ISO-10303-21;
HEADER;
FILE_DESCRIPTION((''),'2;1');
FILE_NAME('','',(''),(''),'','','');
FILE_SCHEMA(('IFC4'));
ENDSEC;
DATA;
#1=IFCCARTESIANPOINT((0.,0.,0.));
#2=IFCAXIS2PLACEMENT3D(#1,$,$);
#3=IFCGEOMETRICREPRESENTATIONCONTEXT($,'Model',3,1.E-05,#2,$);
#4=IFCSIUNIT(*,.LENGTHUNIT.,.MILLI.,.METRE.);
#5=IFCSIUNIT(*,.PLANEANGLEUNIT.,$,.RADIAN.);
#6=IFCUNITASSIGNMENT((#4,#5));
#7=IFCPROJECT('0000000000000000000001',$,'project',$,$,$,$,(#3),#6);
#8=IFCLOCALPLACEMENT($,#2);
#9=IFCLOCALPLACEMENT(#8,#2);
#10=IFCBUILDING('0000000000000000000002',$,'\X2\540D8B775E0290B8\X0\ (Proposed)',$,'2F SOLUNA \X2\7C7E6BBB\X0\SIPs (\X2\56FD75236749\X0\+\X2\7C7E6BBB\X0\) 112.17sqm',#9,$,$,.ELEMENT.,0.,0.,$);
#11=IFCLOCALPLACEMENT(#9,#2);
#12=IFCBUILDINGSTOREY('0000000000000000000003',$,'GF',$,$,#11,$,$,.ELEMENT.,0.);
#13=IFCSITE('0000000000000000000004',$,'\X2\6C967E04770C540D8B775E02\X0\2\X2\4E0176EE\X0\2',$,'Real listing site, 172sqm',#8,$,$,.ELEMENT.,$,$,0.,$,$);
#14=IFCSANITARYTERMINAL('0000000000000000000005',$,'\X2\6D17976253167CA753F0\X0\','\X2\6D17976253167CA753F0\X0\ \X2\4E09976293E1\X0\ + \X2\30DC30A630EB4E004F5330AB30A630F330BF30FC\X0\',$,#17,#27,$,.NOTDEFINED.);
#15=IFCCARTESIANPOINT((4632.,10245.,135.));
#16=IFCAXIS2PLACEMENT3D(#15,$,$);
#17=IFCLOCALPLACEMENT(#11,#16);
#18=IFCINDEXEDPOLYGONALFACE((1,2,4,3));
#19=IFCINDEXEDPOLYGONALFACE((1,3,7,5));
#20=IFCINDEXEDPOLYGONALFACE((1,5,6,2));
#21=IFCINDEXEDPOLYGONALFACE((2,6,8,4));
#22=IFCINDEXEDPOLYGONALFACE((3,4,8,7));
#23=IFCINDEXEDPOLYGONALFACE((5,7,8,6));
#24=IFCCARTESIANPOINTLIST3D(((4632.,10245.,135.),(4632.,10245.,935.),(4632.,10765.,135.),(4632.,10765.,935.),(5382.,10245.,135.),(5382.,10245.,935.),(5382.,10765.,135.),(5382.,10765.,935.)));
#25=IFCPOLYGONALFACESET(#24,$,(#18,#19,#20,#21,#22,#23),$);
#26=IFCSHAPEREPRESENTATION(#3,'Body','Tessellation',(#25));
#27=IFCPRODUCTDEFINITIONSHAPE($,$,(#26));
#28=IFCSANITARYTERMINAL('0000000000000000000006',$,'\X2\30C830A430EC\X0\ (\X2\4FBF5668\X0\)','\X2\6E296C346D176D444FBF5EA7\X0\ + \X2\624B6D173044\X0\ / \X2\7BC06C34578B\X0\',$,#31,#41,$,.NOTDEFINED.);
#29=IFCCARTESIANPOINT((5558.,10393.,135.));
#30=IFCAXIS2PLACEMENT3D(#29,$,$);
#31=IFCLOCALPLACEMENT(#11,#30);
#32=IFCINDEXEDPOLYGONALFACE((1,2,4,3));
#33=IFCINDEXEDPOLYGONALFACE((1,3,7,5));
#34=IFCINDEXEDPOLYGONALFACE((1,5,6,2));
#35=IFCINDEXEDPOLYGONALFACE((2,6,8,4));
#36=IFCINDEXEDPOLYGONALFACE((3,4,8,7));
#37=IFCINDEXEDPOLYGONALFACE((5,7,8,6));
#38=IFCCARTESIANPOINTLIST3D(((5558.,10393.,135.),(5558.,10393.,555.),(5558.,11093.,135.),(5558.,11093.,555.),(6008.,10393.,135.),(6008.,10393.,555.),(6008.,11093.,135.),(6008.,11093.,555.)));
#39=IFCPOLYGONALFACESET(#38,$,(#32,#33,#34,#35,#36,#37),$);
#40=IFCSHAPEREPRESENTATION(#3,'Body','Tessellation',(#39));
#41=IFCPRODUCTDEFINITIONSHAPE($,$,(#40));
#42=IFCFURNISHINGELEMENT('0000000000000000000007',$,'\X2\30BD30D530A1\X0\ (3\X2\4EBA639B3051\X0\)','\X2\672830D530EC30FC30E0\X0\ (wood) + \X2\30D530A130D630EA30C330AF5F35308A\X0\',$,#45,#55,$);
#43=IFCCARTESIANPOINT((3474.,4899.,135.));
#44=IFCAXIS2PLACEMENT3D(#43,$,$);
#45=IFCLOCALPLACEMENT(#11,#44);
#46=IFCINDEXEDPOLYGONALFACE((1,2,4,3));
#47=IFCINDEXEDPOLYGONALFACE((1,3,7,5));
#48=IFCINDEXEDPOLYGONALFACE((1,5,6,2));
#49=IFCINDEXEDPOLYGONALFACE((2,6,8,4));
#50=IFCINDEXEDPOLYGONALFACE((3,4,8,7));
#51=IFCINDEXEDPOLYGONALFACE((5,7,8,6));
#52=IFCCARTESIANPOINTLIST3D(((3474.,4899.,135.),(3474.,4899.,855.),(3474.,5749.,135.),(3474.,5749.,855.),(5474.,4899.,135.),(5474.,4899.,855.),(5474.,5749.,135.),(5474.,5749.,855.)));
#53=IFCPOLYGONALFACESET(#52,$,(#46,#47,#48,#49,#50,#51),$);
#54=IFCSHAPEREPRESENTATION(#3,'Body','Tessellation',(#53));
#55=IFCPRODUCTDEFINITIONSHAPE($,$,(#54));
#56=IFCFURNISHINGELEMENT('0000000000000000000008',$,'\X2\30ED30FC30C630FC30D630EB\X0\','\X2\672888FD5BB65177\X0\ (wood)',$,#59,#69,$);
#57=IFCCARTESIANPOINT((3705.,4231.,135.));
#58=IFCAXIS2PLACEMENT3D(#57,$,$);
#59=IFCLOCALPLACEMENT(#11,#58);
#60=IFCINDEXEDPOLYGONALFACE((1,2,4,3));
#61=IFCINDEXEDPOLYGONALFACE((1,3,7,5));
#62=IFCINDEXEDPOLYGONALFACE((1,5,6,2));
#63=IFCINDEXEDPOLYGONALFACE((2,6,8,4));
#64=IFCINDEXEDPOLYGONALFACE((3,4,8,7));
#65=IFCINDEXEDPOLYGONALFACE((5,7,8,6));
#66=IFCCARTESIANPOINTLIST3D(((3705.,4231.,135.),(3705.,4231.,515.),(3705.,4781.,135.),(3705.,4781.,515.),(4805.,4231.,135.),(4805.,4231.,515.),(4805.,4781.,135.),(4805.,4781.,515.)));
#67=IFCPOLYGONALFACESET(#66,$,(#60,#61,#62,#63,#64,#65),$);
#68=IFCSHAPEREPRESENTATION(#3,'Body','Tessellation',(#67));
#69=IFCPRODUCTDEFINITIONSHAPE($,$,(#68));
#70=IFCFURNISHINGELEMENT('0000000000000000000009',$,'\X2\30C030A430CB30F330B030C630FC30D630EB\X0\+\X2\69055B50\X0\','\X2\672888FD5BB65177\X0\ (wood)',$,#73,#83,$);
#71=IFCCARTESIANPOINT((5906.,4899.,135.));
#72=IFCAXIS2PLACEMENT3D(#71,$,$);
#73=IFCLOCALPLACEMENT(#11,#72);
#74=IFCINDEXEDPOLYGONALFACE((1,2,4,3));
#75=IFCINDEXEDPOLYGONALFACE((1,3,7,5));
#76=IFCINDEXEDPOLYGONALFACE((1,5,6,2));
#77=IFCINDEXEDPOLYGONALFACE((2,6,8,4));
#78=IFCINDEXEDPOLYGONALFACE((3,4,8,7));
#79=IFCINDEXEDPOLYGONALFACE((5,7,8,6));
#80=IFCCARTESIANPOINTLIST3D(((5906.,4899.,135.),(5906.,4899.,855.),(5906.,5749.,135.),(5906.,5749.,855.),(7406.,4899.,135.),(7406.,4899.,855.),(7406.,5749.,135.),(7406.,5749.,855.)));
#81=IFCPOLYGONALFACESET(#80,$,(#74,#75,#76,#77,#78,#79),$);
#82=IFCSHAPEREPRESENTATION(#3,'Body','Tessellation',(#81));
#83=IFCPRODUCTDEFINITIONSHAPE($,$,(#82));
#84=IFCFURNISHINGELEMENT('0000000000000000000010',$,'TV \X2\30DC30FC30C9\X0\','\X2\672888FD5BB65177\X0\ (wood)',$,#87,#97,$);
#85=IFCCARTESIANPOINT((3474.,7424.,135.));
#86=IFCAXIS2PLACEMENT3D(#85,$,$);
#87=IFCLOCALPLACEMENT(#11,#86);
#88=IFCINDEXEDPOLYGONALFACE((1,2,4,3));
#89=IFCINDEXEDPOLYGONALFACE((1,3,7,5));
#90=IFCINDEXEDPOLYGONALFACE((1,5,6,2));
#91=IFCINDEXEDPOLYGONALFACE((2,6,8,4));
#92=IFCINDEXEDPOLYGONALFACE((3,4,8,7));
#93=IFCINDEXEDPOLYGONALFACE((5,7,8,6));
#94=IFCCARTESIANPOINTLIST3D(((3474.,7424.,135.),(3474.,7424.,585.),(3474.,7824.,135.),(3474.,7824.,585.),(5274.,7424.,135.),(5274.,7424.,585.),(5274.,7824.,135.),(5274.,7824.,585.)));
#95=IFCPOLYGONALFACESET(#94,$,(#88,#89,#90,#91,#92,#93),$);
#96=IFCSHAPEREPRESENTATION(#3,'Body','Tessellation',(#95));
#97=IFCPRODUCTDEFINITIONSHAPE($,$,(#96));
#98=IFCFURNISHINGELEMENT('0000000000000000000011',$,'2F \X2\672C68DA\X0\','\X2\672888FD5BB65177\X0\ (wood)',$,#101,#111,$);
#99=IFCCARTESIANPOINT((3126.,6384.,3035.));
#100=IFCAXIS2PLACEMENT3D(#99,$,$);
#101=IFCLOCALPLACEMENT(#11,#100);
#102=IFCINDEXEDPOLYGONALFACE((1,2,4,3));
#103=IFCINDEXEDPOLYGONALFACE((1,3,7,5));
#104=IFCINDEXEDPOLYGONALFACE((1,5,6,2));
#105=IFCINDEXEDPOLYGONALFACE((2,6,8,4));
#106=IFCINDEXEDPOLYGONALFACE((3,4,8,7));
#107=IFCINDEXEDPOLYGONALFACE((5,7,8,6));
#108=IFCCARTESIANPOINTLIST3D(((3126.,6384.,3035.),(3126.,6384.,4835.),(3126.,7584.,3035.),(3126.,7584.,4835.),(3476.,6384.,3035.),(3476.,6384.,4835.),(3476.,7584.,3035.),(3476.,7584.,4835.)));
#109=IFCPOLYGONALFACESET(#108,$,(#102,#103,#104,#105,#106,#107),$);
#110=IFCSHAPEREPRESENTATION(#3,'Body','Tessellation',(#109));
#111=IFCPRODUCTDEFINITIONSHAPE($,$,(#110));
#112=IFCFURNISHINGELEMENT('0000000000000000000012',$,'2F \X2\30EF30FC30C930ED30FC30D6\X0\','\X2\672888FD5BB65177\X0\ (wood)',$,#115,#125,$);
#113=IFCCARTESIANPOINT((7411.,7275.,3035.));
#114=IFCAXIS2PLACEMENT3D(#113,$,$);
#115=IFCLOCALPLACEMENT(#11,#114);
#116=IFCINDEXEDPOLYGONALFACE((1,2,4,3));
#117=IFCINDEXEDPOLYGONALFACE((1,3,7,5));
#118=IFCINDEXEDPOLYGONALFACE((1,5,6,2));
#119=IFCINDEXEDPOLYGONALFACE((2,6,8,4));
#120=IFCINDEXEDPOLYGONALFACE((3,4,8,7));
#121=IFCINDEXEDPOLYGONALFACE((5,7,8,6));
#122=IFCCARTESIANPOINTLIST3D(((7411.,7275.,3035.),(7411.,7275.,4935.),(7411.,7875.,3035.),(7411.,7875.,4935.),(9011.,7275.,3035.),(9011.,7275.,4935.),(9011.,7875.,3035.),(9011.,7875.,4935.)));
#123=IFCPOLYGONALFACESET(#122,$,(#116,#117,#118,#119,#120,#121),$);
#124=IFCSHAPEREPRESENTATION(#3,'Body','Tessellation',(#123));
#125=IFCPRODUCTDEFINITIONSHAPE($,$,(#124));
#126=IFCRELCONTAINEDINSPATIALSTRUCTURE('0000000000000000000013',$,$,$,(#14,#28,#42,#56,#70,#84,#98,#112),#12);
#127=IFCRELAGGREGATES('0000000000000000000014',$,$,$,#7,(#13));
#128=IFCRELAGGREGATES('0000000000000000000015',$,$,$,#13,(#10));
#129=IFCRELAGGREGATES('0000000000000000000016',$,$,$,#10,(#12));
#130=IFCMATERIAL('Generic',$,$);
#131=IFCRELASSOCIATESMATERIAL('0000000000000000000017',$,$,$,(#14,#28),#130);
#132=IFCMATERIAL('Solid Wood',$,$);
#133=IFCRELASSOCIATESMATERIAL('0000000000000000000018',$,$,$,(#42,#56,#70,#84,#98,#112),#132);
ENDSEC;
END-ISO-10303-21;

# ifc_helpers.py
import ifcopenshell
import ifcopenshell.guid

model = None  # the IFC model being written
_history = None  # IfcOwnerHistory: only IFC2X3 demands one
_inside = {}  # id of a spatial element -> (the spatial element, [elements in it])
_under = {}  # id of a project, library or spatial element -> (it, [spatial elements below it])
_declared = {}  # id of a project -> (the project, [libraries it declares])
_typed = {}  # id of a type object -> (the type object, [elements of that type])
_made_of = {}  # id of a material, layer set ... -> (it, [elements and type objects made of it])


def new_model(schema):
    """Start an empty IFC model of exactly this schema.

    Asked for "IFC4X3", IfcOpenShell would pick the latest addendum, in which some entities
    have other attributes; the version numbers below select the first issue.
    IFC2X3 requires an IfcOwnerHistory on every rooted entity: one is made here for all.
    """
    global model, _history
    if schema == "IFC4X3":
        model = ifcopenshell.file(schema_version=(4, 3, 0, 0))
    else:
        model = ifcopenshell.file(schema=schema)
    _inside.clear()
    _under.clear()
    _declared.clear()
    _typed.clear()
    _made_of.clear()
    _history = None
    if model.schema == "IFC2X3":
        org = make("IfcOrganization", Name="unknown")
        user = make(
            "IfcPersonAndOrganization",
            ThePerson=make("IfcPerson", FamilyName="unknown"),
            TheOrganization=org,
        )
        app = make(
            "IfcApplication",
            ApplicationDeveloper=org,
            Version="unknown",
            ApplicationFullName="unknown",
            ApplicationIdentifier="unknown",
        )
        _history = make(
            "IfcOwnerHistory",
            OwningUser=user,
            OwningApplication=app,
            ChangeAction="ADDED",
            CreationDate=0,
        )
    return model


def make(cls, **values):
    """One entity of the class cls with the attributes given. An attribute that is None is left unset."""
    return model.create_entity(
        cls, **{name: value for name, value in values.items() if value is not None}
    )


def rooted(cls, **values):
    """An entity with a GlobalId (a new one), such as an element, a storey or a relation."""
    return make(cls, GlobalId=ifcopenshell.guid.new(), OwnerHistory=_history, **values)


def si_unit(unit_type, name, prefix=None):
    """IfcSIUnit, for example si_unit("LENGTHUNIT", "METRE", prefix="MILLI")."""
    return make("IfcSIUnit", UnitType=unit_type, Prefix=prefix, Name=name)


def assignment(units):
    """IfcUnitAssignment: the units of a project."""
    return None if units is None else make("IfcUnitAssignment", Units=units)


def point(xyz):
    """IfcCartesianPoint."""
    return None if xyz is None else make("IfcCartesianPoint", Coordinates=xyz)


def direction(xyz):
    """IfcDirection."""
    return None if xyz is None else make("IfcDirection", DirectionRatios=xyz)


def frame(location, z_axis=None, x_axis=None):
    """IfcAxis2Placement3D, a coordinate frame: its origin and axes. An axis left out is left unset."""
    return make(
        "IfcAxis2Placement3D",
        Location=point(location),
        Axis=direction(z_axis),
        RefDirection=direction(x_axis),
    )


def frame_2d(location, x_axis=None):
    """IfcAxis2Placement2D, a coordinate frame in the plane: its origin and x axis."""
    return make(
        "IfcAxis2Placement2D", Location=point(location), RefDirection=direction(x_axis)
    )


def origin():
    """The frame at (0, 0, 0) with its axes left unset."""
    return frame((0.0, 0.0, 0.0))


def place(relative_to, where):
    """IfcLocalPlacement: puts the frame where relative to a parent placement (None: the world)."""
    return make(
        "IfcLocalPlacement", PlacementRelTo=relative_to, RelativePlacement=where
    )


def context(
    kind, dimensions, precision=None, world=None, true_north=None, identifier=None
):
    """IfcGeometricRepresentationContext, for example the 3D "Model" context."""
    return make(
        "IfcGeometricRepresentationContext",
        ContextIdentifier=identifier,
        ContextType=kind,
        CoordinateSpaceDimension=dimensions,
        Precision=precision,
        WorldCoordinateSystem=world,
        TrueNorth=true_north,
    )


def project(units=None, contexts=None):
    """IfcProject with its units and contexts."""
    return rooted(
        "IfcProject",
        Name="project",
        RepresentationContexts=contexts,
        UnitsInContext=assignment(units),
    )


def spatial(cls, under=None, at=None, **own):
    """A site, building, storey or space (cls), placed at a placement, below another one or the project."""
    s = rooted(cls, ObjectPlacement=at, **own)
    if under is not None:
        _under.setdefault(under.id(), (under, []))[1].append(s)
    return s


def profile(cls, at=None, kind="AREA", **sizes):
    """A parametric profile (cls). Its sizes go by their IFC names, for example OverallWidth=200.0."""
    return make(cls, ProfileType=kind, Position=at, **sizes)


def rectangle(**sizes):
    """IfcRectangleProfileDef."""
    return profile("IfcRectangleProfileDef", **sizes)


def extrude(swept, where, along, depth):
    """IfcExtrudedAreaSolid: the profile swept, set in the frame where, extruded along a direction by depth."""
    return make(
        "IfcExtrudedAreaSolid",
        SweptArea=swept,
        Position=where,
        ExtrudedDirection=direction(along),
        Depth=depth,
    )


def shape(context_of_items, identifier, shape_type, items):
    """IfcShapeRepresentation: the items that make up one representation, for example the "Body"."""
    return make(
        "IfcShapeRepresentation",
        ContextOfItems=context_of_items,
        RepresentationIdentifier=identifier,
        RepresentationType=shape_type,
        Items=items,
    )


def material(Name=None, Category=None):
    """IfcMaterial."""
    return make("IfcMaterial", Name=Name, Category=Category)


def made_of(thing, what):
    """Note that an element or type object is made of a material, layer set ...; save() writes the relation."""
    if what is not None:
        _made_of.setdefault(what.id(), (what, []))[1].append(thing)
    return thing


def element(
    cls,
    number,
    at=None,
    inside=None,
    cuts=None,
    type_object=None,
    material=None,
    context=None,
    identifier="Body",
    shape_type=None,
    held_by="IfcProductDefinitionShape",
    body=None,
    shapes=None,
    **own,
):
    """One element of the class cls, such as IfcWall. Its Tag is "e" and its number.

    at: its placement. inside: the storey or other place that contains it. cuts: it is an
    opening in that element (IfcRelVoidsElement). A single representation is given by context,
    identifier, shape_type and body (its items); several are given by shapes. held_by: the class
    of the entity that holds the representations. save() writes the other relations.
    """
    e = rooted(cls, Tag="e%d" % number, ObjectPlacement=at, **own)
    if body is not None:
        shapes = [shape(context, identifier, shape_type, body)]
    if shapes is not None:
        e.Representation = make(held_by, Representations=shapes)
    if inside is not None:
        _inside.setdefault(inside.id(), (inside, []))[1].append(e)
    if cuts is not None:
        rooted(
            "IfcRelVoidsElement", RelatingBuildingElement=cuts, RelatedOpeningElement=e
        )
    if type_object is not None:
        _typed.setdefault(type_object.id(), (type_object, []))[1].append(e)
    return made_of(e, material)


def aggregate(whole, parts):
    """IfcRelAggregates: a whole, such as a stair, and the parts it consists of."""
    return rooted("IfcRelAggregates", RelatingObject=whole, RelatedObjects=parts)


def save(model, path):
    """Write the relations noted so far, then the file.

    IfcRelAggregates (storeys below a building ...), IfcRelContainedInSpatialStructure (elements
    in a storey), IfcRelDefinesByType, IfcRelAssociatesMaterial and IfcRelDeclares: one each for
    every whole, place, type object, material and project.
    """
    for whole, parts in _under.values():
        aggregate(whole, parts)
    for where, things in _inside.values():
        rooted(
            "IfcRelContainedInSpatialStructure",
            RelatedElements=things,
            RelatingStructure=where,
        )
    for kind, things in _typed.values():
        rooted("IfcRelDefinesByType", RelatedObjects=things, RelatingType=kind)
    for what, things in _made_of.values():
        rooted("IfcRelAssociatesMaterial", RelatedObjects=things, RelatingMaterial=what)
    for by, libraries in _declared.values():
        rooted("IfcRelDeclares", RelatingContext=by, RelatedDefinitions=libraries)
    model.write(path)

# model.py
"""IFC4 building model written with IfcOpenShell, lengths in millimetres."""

from ifc_helpers import new_model, si_unit, frame, frame_2d, origin, place, context, project, spatial, rectangle, extrude, material, element, save


model = new_model("IFC4")

# Units and contexts
model_context = context("Model", 3, precision=1e-05, world=origin())
ifc_project = project(units=[si_unit("LENGTHUNIT", "METRE", prefix="MILLI"), si_unit("PLANEANGLEUNIT", "RADIAN")], contexts=[model_context])

# Site, building, storey
site_placement = place(None, origin())
site = spatial("IfcSite", under=ifc_project, at=site_placement, Name="沖縄県名護市2丁目2", ObjectType="Real listing site, 172sqm", CompositionType="ELEMENT", RefElevation=0.0)
building_placement = place(site_placement, origin())
building = spatial("IfcBuilding", under=site, at=building_placement, Name="名護市邸 (Proposed)", ObjectType="2F SOLUNA 籾殻SIPs (国産杉+籾殻) 112.17sqm", CompositionType="ELEMENT", ElevationOfRefHeight=0.0, ElevationOfTerrain=0.0)
storey_placement = place(building_placement, origin())
storey = spatial("IfcBuildingStorey", under=building, at=storey_placement, Name="GF", CompositionType="ELEMENT", Elevation=0.0)

# Shared definitions
ifc_material_1 = material(Name="Generic")

# Shared definitions
ifc_material_2 = material(Name="Solid Wood")

# Sanitary terminals
sanitary_terminal_1_placement = place(storey_placement, frame((4632.0, 10245.0, 135.0)))
element("IfcSanitaryTerminal", 1, at=sanitary_terminal_1_placement, inside=storey, material=ifc_material_1, Name="洗面化粧台", Description="洗面化粧台 三面鏡 + ボウル一体カウンター", PredefinedType="NOTDEFINED", context=model_context, shape_type="SweptSolid", body=[
    extrude(rectangle(XDim=750.0, YDim=520.0, at=frame_2d((375.0, 260.0))), frame((4632.0, 10245.0, 135.0)), (0.0, 0.0, 1.0), 800.0),
])
sanitary_terminal_2_placement = place(storey_placement, frame((5558.0, 10393.0, 135.0)))
element("IfcSanitaryTerminal", 2, at=sanitary_terminal_2_placement, inside=storey, material=ifc_material_1, Name="トイレ (便器)", Description="温水洗浄便座 + 手洗い / 節水型", PredefinedType="NOTDEFINED", context=model_context, shape_type="SweptSolid", body=[
    extrude(rectangle(XDim=450.0, YDim=700.0, at=frame_2d((225.0, 350.0))), frame((5558.0, 10393.0, 135.0)), (0.0, 0.0, 1.0), 420.0),
])

# Furnishing elements
furnishing_1_placement = place(storey_placement, frame((3474.0, 4899.0, 135.0)))
element("IfcFurnishingElement", 3, at=furnishing_1_placement, inside=storey, material=ifc_material_2, Name="ソファ (3人掛け)", Description="木フレーム (wood) + ファブリック張り", context=model_context, shape_type="SweptSolid", body=[
    extrude(rectangle(XDim=2000.0, YDim=850.0, at=frame_2d((1000.0, 425.0))), frame((3474.0, 4899.0, 135.0)), (0.0, 0.0, 1.0), 720.0),
])
furnishing_2_placement = place(storey_placement, frame((3705.0, 4231.0, 135.0)))
element("IfcFurnishingElement", 4, at=furnishing_2_placement, inside=storey, material=ifc_material_2, Name="ローテーブル", Description="木製家具 (wood)", context=model_context, shape_type="SweptSolid", body=[
    extrude(rectangle(XDim=1100.0, YDim=550.0, at=frame_2d((550.0, 275.0))), frame((3705.0, 4231.0, 135.0)), (0.0, 0.0, 1.0), 380.0),
])
furnishing_3_placement = place(storey_placement, frame((5906.0, 4899.0, 135.0)))
element("IfcFurnishingElement", 5, at=furnishing_3_placement, inside=storey, material=ifc_material_2, Name="ダイニングテーブル+椅子", Description="木製家具 (wood)", context=model_context, shape_type="SweptSolid", body=[
    extrude(rectangle(XDim=1500.0, YDim=850.0, at=frame_2d((750.0, 425.0))), frame((5906.0, 4899.0, 135.0)), (0.0, 0.0, 1.0), 720.0),
])
furnishing_4_placement = place(storey_placement, frame((3474.0, 7424.0, 135.0)))
element("IfcFurnishingElement", 6, at=furnishing_4_placement, inside=storey, material=ifc_material_2, Name="TV ボード", Description="木製家具 (wood)", context=model_context, shape_type="SweptSolid", body=[
    extrude(rectangle(XDim=1800.0, YDim=400.0, at=frame_2d((900.0, 200.0))), frame((3474.0, 7424.0, 135.0)), (0.0, 0.0, 1.0), 450.0),
])
furnishing_5_placement = place(storey_placement, frame((3126.0, 6384.0, 3035.0)))
element("IfcFurnishingElement", 7, at=furnishing_5_placement, inside=storey, material=ifc_material_2, Name="2F 本棚", Description="木製家具 (wood)", context=model_context, shape_type="SweptSolid", body=[
    extrude(rectangle(XDim=350.0, YDim=1200.0, at=frame_2d((175.0, 600.0))), frame((3126.0, 6384.0, 3035.0)), (0.0, 0.0, 1.0), 1800.0),
])
furnishing_6_placement = place(storey_placement, frame((7411.0, 7275.0, 3035.0)))
element("IfcFurnishingElement", 8, at=furnishing_6_placement, inside=storey, material=ifc_material_2, Name="2F ワードローブ", Description="木製家具 (wood)", context=model_context, shape_type="SweptSolid", body=[
    extrude(rectangle(XDim=1600.0, YDim=600.0, at=frame_2d((800.0, 300.0))), frame((7411.0, 7275.0, 3035.0)), (0.0, 0.0, 1.0), 1900.0),
])

save(model, "model.ifc")
